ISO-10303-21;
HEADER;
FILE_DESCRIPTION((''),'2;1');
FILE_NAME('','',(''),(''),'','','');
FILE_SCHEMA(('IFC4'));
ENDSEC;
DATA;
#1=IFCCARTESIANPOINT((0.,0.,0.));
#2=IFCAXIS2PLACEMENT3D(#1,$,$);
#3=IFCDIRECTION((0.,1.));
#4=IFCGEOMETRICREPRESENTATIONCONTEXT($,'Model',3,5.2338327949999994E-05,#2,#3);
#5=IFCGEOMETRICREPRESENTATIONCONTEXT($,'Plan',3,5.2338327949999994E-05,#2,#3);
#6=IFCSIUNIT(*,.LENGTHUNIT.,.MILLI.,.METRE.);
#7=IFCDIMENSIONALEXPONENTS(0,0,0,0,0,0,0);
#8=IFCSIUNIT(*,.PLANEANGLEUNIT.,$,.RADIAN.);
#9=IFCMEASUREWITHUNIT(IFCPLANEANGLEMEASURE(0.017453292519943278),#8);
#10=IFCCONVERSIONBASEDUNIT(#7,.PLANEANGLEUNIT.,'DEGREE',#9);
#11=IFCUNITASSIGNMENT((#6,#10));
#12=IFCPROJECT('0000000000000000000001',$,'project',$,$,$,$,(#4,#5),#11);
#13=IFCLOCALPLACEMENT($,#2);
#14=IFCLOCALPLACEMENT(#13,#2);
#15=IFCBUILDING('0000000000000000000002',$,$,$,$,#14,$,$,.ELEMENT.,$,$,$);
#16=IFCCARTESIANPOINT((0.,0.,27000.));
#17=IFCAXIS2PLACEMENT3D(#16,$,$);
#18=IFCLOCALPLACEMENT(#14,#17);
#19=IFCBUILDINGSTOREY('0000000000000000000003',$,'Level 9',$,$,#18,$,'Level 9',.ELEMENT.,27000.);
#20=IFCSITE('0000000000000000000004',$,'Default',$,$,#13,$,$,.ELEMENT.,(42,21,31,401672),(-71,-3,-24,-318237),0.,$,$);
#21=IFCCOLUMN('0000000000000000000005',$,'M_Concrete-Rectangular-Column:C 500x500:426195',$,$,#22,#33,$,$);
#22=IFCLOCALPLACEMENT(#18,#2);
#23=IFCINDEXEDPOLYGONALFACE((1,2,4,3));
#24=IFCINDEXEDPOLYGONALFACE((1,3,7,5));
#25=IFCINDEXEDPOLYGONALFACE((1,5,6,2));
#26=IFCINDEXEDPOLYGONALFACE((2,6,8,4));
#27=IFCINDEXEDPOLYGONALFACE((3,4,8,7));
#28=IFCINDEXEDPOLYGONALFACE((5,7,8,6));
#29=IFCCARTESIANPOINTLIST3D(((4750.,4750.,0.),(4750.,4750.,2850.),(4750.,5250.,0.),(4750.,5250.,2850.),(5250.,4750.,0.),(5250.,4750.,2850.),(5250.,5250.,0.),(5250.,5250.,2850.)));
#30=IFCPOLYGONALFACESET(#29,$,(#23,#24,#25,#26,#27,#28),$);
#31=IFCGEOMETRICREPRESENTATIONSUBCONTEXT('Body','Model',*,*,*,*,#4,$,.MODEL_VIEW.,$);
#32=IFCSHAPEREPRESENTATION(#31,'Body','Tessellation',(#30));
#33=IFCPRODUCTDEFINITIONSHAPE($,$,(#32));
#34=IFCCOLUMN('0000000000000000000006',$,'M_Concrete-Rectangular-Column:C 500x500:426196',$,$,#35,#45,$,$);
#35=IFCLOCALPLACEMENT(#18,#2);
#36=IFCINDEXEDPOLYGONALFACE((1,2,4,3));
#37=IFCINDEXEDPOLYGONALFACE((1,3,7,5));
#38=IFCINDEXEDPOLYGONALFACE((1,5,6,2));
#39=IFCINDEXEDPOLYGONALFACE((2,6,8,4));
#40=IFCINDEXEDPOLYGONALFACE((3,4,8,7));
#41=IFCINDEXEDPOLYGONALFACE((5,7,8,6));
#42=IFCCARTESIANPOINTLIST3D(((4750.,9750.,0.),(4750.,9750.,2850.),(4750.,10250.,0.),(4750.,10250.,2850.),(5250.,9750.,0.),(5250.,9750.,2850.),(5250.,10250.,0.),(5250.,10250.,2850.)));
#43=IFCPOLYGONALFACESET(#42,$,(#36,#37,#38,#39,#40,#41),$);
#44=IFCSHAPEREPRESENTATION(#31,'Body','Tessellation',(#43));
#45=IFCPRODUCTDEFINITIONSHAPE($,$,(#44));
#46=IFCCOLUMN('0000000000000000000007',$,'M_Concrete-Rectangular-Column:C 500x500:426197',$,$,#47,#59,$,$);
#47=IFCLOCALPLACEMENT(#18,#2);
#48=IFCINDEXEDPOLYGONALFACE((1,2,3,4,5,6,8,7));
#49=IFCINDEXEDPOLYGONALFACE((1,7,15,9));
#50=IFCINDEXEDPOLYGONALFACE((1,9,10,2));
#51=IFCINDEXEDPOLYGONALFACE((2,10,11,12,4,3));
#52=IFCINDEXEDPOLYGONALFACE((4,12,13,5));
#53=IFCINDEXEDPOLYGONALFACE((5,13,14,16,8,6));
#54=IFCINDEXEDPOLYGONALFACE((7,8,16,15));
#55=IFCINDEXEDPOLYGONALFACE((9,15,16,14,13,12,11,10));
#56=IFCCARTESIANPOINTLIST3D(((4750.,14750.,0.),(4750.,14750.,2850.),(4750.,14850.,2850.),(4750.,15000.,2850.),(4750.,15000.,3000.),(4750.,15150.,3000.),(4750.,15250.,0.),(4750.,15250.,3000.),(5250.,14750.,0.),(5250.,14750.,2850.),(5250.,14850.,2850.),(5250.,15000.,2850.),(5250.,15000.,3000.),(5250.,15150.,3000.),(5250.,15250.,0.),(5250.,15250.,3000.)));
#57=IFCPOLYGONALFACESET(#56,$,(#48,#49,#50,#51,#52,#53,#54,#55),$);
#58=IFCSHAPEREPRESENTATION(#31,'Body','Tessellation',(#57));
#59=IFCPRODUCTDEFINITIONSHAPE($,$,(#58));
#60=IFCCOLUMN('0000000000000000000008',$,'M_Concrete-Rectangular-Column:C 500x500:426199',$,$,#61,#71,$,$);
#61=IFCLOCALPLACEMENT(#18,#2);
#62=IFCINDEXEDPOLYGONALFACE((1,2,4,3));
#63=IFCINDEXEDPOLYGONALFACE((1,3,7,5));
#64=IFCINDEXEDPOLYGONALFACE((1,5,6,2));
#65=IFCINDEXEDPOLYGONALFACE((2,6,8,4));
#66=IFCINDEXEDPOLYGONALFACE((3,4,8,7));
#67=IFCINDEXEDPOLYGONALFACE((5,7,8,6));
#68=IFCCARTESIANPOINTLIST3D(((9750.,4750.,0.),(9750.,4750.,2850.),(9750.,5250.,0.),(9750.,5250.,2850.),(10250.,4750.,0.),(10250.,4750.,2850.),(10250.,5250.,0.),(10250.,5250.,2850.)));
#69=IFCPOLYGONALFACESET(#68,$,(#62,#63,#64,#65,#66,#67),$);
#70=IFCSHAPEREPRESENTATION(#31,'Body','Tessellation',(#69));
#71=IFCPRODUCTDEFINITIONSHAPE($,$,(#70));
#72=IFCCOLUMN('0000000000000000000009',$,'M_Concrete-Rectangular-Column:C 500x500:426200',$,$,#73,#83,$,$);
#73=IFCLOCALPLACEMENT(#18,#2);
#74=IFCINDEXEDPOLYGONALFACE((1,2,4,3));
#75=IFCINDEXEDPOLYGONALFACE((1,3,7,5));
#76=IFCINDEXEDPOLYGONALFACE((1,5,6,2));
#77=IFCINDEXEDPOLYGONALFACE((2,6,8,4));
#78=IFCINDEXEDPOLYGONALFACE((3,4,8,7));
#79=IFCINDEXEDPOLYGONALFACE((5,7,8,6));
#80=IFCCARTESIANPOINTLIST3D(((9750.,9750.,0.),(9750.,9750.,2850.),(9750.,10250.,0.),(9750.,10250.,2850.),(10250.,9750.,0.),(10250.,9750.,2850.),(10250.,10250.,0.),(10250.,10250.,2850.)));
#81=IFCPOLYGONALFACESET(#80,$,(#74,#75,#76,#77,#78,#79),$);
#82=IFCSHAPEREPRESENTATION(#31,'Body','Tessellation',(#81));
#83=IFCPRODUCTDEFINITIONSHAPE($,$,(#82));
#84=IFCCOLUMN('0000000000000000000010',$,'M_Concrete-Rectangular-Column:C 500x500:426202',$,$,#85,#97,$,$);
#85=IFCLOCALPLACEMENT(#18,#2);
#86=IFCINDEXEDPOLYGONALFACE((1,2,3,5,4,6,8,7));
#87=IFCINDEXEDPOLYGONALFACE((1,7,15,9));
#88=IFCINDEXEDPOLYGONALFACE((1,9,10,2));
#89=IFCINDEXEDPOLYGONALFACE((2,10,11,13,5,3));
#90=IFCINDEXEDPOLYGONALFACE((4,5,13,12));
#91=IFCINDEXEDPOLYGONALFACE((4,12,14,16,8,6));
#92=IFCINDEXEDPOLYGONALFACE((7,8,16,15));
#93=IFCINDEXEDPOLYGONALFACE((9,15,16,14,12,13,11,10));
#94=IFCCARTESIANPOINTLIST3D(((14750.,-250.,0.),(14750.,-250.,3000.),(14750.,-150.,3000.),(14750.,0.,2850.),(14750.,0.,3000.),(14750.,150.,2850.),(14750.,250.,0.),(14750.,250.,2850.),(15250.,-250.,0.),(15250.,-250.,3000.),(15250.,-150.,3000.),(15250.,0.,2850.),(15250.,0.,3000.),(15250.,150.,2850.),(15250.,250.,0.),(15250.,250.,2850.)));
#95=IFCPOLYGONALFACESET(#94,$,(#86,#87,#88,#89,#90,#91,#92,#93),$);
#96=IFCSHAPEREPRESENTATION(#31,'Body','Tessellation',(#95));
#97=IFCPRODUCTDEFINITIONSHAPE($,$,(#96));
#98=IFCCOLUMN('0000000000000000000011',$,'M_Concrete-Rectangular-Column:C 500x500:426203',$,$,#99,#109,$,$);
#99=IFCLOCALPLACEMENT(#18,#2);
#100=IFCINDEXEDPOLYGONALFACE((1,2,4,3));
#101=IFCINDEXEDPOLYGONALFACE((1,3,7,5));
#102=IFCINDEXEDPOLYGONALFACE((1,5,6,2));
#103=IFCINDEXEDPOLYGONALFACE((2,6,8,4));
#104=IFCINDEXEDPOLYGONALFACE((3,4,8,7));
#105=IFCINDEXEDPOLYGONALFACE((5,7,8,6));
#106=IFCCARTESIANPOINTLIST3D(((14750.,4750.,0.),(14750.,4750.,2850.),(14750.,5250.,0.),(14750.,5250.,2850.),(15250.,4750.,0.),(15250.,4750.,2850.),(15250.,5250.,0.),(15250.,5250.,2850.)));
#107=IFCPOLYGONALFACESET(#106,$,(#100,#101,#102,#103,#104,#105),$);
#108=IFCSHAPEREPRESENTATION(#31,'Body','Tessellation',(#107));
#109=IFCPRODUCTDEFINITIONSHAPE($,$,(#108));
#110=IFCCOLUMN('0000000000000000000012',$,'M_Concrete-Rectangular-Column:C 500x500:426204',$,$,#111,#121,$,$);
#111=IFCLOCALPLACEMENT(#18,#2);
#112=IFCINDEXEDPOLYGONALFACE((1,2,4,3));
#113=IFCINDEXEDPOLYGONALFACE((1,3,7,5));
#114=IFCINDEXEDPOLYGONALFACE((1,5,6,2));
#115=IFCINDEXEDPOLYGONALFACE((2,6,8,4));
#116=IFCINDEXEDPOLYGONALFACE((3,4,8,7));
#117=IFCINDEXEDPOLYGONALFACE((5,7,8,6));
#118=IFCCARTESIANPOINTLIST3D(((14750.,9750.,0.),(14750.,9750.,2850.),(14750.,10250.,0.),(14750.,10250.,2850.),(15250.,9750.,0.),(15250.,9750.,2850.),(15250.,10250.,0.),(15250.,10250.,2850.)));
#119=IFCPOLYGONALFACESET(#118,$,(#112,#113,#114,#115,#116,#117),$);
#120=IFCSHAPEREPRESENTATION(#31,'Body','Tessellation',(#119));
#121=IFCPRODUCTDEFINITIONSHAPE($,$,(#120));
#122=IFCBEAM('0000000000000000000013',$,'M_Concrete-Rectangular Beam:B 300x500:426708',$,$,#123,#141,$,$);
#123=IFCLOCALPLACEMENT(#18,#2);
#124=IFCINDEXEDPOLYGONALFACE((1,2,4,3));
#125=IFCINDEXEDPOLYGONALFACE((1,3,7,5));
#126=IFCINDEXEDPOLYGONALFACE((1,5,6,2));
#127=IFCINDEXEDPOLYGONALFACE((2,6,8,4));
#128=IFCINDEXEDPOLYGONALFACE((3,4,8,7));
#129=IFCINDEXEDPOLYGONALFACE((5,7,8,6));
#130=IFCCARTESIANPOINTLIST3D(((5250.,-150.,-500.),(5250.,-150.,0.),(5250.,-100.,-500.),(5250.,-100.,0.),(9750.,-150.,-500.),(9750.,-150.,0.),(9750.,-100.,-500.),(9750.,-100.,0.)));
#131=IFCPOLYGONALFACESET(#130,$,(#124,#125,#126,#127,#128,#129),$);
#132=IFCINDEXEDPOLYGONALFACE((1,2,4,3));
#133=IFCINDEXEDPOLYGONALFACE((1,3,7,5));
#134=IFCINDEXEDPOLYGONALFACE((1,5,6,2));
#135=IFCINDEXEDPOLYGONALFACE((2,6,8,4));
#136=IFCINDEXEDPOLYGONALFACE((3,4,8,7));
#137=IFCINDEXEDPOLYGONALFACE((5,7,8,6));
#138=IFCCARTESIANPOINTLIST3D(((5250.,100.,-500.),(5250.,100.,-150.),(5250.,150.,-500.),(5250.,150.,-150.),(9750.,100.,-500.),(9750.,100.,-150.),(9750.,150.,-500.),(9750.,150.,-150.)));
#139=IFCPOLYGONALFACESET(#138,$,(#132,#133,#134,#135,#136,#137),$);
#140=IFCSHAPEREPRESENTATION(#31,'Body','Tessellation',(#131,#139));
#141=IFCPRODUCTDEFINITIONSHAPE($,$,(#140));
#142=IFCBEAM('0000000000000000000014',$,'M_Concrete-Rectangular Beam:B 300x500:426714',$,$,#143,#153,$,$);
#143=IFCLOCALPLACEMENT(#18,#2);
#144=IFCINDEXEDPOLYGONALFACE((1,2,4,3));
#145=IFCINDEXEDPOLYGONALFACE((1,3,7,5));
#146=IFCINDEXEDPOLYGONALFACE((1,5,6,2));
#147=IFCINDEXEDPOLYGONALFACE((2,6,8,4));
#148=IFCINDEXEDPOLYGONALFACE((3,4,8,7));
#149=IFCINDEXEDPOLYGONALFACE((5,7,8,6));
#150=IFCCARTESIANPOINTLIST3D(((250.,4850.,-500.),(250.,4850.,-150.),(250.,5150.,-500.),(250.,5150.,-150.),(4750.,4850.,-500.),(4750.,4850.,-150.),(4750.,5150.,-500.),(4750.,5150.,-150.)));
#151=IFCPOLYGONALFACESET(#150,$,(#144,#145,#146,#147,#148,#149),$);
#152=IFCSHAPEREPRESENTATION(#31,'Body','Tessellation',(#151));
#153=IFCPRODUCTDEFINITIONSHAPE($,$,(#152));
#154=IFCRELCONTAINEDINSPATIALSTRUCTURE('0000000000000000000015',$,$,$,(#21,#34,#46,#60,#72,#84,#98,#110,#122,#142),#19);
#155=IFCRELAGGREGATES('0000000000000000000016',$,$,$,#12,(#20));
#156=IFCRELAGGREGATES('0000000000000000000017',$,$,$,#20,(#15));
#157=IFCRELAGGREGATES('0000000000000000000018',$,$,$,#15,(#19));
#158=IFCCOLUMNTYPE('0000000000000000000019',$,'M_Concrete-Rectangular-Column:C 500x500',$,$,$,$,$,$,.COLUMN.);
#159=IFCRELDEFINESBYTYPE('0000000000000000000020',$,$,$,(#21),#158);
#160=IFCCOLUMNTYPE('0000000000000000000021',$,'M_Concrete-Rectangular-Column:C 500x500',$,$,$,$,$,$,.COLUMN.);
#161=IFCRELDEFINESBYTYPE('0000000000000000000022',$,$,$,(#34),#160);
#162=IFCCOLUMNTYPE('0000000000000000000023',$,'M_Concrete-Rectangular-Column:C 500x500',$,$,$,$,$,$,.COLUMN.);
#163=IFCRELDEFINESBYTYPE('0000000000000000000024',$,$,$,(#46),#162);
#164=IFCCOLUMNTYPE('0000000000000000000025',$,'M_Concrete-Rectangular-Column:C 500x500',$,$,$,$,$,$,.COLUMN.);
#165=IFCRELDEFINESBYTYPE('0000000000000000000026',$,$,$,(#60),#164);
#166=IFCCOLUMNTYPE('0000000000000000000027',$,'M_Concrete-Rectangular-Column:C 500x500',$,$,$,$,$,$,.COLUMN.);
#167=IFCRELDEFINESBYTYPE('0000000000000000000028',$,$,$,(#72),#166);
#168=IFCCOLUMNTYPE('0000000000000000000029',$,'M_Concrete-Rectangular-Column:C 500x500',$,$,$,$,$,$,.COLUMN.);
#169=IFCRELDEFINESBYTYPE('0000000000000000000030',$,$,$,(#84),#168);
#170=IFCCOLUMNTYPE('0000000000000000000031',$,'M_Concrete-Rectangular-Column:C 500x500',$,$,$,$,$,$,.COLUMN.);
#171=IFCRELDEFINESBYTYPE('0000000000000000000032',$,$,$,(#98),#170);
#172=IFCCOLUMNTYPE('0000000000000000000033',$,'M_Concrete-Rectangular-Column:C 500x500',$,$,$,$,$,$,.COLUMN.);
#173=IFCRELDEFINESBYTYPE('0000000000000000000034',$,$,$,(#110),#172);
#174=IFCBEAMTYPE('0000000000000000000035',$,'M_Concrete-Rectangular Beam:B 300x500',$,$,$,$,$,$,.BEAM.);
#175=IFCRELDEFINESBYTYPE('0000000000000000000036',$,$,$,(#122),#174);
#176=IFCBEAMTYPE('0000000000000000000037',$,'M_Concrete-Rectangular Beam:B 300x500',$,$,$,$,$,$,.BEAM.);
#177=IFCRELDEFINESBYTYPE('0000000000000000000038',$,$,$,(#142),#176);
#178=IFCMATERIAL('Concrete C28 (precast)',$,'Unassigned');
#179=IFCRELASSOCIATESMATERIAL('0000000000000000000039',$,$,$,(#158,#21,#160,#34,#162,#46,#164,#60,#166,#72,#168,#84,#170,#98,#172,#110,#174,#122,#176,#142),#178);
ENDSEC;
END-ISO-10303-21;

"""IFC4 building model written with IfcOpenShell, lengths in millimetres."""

from ifc_helpers import new_model, entity, si_unit, converted_unit, direction, frame, origin, place, context, subcontext, project, spatial, indexed_curve, outline, extrude, source, transform, mapped, material, type_object, type_shapes, element, save


model = new_model("IFC4")

# Units and contexts
model_context = context("Model", 3, precision=5.2338327949999994e-05, world=origin(), true_north=direction((0.0, 1.0)))
plan_context = context("Plan", 3, precision=5.2338327949999994e-05, world=origin(), true_north=direction((0.0, 1.0)))
body_context = subcontext(model_context, "Body", "Model", "MODEL_VIEW")
ifc_project = project(units=[si_unit("LENGTHUNIT", "METRE", prefix="MILLI"), converted_unit("PLANEANGLEUNIT", "DEGREE", entity("IfcPlaneAngleMeasure", 0.017453292519943278), si_unit("PLANEANGLEUNIT", "RADIAN"), dimensions=[0, 0, 0, 0, 0, 0, 0])], contexts=[model_context, plan_context])

# Site, building, storey
site_placement = place(None, origin())
site = spatial("IfcSite", under=ifc_project, at=site_placement, Name="Default", CompositionType="ELEMENT", RefLatitude=(42, 21, 31, 401672), RefLongitude=(-71, -3, -24, -318237), RefElevation=0.0)
building_placement = place(site_placement, origin())
building = spatial("IfcBuilding", under=site, at=building_placement, CompositionType="ELEMENT")
storey_placement = place(building_placement, frame((0.0, 0.0, 27000.0)))
storey = spatial("IfcBuildingStorey", under=building, at=storey_placement, Name="Level 9", LongName="Level 9", CompositionType="ELEMENT", Elevation=27000.0)

# Columns
ifc_material = material(Name="Concrete C28 (precast)", Category="Unassigned")
column_type_1 = type_object("IfcColumnType", Name="M_Concrete-Rectangular-Column:C 500x500", PredefinedType="COLUMN", material=ifc_material)
shared_shape_1 = source(origin(), body_context, "Body", "SweptSolid", [
    extrude(outline(indexed_curve([(-250.0, -250.0), (250.0, -250.0), (250.0, 250.0), (-250.0, 250.0), (-250.0, -250.0)], self_intersect=False)), frame((5000.0, 5000.0, 27000.0), z_axis=(0.0, 0.0, 1.0), x_axis=(-1.0, 0.0, 0.0)), (0.0, 0.0, 1.0), 2850.0),
])
type_shapes(column_type_1, [shared_shape_1])
column_1_placement = place(storey_placement, frame((0.0, 0.0, -27000.0)))
element("IfcColumn", 1, at=column_1_placement, inside=storey, type_object=column_type_1, material=ifc_material, Name="M_Concrete-Rectangular-Column:C 500x500:426195", context=body_context, shape_type="MappedRepresentation", body=[
    mapped(shared_shape_1, transform((0.0, 0.0, 0.0), scale=1.0)),
])
column_type_2 = type_object("IfcColumnType", Name="M_Concrete-Rectangular-Column:C 500x500", PredefinedType="COLUMN", material=ifc_material)
shared_shape_2 = source(origin(), body_context, "Body", "SweptSolid", [
    extrude(outline(indexed_curve([(-250.0, -250.0), (250.0, -250.0), (250.0, 250.0), (-250.0, 250.0), (-250.0, -250.0)], self_intersect=False)), frame((5000.0, 10000.0, 27000.0), z_axis=(0.0, 0.0, 1.0), x_axis=(-1.0, 0.0, 0.0)), (0.0, 0.0, 1.0), 2850.0),
])
type_shapes(column_type_2, [shared_shape_2])
column_2_placement = place(storey_placement, frame((0.0, 0.0, -27000.0)))
element("IfcColumn", 2, at=column_2_placement, inside=storey, type_object=column_type_2, material=ifc_material, Name="M_Concrete-Rectangular-Column:C 500x500:426196", context=body_context, shape_type="MappedRepresentation", body=[
    mapped(shared_shape_2, transform((0.0, 0.0, 0.0), scale=1.0)),
])
column_type_3 = type_object("IfcColumnType", Name="M_Concrete-Rectangular-Column:C 500x500", PredefinedType="COLUMN", material=ifc_material)
shared_shape_3 = source(origin(), body_context, "Body", "SweptSolid", [
    extrude(outline(indexed_curve([(-2193.8, -250.0), (806.2, -250.0), (806.2, -150.0), (806.2, 0.0), (656.2, 0.0), (656.2, 150.0), (656.2, 250.0), (-2193.8, 250.0), (-2193.8, -250.0)], self_intersect=False)), frame((4750.0, 15000.0, 29193.8), z_axis=(1.0, 0.0, 0.0), x_axis=(0.0, 0.0, 1.0)), (0.0, 0.0, 1.0), 500.0),
])
type_shapes(column_type_3, [shared_shape_3])
column_3_placement = place(storey_placement, frame((0.0, 0.0, -27000.0)))
element("IfcColumn", 3, at=column_3_placement, inside=storey, type_object=column_type_3, material=ifc_material, Name="M_Concrete-Rectangular-Column:C 500x500:426197", context=body_context, shape_type="MappedRepresentation", body=[
    mapped(shared_shape_3, transform((0.0, 0.0, 0.0), scale=1.0)),
])
column_type_4 = type_object("IfcColumnType", Name="M_Concrete-Rectangular-Column:C 500x500", PredefinedType="COLUMN", material=ifc_material)
shared_shape_4 = source(origin(), body_context, "Body", "SweptSolid", [
    extrude(outline(indexed_curve([(-250.0, -250.0), (250.0, -250.0), (250.0, 250.0), (-250.0, 250.0), (-250.0, -250.0)], self_intersect=False)), frame((10000.0, 5000.0, 27000.0), z_axis=(0.0, 0.0, 1.0), x_axis=(-1.0, 0.0, 0.0)), (0.0, 0.0, 1.0), 2850.0),
])
type_shapes(column_type_4, [shared_shape_4])
column_4_placement = place(storey_placement, frame((0.0, 0.0, -27000.0)))
element("IfcColumn", 4, at=column_4_placement, inside=storey, type_object=column_type_4, material=ifc_material, Name="M_Concrete-Rectangular-Column:C 500x500:426199", context=body_context, shape_type="MappedRepresentation", body=[
    mapped(shared_shape_4, transform((0.0, 0.0, 0.0), scale=1.0)),
])
column_type_5 = type_object("IfcColumnType", Name="M_Concrete-Rectangular-Column:C 500x500", PredefinedType="COLUMN", material=ifc_material)
shared_shape_5 = source(origin(), body_context, "Body", "SweptSolid", [
    extrude(outline(indexed_curve([(-250.0, -250.0), (250.0, -250.0), (250.0, 250.0), (-250.0, 250.0), (-250.0, -250.0)], self_intersect=False)), frame((10000.0, 10000.0, 27000.0), z_axis=(0.0, 0.0, 1.0), x_axis=(-1.0, 0.0, 0.0)), (0.0, 0.0, 1.0), 2850.0),
])
type_shapes(column_type_5, [shared_shape_5])
column_5_placement = place(storey_placement, frame((0.0, 0.0, -27000.0)))
element("IfcColumn", 5, at=column_5_placement, inside=storey, type_object=column_type_5, material=ifc_material, Name="M_Concrete-Rectangular-Column:C 500x500:426200", context=body_context, shape_type="MappedRepresentation", body=[
    mapped(shared_shape_5, transform((0.0, 0.0, 0.0), scale=1.0)),
])
column_type_6 = type_object("IfcColumnType", Name="M_Concrete-Rectangular-Column:C 500x500", PredefinedType="COLUMN", material=ifc_material)
shared_shape_6 = source(origin(), body_context, "Body", "SweptSolid", [
    extrude(outline(indexed_curve([(-2193.8, -250.0), (656.2, -250.0), (656.2, -150.0), (656.2, 0.0), (806.2, 0.0), (806.2, 150.0), (806.2, 250.0), (-2193.8, 250.0), (-2193.8, -250.0)], self_intersect=False)), frame((14750.0, 0.0, 29193.8), z_axis=(1.0, 0.0, 0.0), x_axis=(0.0, 0.0, 1.0)), (0.0, 0.0, 1.0), 500.0),
])
type_shapes(column_type_6, [shared_shape_6])
column_6_placement = place(storey_placement, frame((0.0, 0.0, -27000.0)))
element("IfcColumn", 6, at=column_6_placement, inside=storey, type_object=column_type_6, material=ifc_material, Name="M_Concrete-Rectangular-Column:C 500x500:426202", context=body_context, shape_type="MappedRepresentation", body=[
    mapped(shared_shape_6, transform((0.0, 0.0, 0.0), scale=1.0)),
])
column_type_7 = type_object("IfcColumnType", Name="M_Concrete-Rectangular-Column:C 500x500", PredefinedType="COLUMN", material=ifc_material)
shared_shape_7 = source(origin(), body_context, "Body", "SweptSolid", [
    extrude(outline(indexed_curve([(-250.0, -250.0), (250.0, -250.0), (250.0, 250.0), (-250.0, 250.0), (-250.0, -250.0)], self_intersect=False)), frame((15000.0, 5000.0, 27000.0), z_axis=(0.0, 0.0, 1.0), x_axis=(-1.0, 0.0, 0.0)), (0.0, 0.0, 1.0), 2850.0),
])
type_shapes(column_type_7, [shared_shape_7])
column_7_placement = place(storey_placement, frame((0.0, 0.0, -27000.0)))
element("IfcColumn", 7, at=column_7_placement, inside=storey, type_object=column_type_7, material=ifc_material, Name="M_Concrete-Rectangular-Column:C 500x500:426203", context=body_context, shape_type="MappedRepresentation", body=[
    mapped(shared_shape_7, transform((0.0, 0.0, 0.0), scale=1.0)),
])
column_type_8 = type_object("IfcColumnType", Name="M_Concrete-Rectangular-Column:C 500x500", PredefinedType="COLUMN", material=ifc_material)
shared_shape_8 = source(origin(), body_context, "Body", "SweptSolid", [
    extrude(outline(indexed_curve([(-250.0, -250.0), (250.0, -250.0), (250.0, 250.0), (-250.0, 250.0), (-250.0, -250.0)], self_intersect=False)), frame((15000.0, 10000.0, 27000.0), z_axis=(0.0, 0.0, 1.0), x_axis=(-1.0, 0.0, 0.0)), (0.0, 0.0, 1.0), 2850.0),
])
type_shapes(column_type_8, [shared_shape_8])
column_8_placement = place(storey_placement, frame((0.0, 0.0, -27000.0)))
element("IfcColumn", 8, at=column_8_placement, inside=storey, type_object=column_type_8, material=ifc_material, Name="M_Concrete-Rectangular-Column:C 500x500:426204", context=body_context, shape_type="MappedRepresentation", body=[
    mapped(shared_shape_8, transform((0.0, 0.0, 0.0), scale=1.0)),
])

# Beams
beam_type_1 = type_object("IfcBeamType", Name="M_Concrete-Rectangular Beam:B 300x500", PredefinedType="BEAM", material=ifc_material)
shared_shape_9 = source(origin(), body_context, "Body", "SweptSolid", [
    extrude(outline(indexed_curve([(-250.0, -25.0), (250.0, -25.0), (250.0, 25.0), (-250.0, 25.0), (-250.0, -25.0)], self_intersect=False)), frame((5250.0, -125.0, 26750.0), z_axis=(1.0, 0.0, 0.0), x_axis=(0.0, 0.0, -1.0)), (0.0, 0.0, 1.0), 4500.0),
    extrude(outline(indexed_curve([(-175.0, -25.0), (175.0, -25.0), (175.0, 25.0), (-175.0, 25.0), (-175.0, -25.0)], self_intersect=False)), frame((5250.0, 125.0, 26675.0), z_axis=(1.0, 0.0, 0.0), x_axis=(0.0, 0.0, -1.0)), (0.0, 0.0, 1.0), 4500.0),
])
type_shapes(beam_type_1, [shared_shape_9])
beam_1_placement = place(storey_placement, frame((0.0, 0.0, -27000.0)))
element("IfcBeam", 9, at=beam_1_placement, inside=storey, type_object=beam_type_1, material=ifc_material, Name="M_Concrete-Rectangular Beam:B 300x500:426708", context=body_context, shape_type="MappedRepresentation", body=[
    mapped(shared_shape_9, transform((0.0, 0.0, 0.0), scale=1.0)),
])
beam_type_2 = type_object("IfcBeamType", Name="M_Concrete-Rectangular Beam:B 300x500", PredefinedType="BEAM", material=ifc_material)
shared_shape_10 = source(origin(), body_context, "Body", "SweptSolid", [
    extrude(outline(indexed_curve([(-175.0, -150.0), (175.0, -150.0), (175.0, 150.0), (-175.0, 150.0), (-175.0, -150.0)], self_intersect=False)), frame((250.0, 5000.0, 26675.0), z_axis=(1.0, 0.0, 0.0), x_axis=(0.0, 0.0, -1.0)), (0.0, 0.0, 1.0), 4500.0),
])
type_shapes(beam_type_2, [shared_shape_10])
beam_2_placement = place(storey_placement, frame((0.0, 0.0, -27000.0)))
element("IfcBeam", 10, at=beam_2_placement, inside=storey, type_object=beam_type_2, material=ifc_material, Name="M_Concrete-Rectangular Beam:B 300x500:426714", context=body_context, shape_type="MappedRepresentation", body=[
    mapped(shared_shape_10, transform((0.0, 0.0, 0.0), scale=1.0)),
])

save(model, "model.ifc")
